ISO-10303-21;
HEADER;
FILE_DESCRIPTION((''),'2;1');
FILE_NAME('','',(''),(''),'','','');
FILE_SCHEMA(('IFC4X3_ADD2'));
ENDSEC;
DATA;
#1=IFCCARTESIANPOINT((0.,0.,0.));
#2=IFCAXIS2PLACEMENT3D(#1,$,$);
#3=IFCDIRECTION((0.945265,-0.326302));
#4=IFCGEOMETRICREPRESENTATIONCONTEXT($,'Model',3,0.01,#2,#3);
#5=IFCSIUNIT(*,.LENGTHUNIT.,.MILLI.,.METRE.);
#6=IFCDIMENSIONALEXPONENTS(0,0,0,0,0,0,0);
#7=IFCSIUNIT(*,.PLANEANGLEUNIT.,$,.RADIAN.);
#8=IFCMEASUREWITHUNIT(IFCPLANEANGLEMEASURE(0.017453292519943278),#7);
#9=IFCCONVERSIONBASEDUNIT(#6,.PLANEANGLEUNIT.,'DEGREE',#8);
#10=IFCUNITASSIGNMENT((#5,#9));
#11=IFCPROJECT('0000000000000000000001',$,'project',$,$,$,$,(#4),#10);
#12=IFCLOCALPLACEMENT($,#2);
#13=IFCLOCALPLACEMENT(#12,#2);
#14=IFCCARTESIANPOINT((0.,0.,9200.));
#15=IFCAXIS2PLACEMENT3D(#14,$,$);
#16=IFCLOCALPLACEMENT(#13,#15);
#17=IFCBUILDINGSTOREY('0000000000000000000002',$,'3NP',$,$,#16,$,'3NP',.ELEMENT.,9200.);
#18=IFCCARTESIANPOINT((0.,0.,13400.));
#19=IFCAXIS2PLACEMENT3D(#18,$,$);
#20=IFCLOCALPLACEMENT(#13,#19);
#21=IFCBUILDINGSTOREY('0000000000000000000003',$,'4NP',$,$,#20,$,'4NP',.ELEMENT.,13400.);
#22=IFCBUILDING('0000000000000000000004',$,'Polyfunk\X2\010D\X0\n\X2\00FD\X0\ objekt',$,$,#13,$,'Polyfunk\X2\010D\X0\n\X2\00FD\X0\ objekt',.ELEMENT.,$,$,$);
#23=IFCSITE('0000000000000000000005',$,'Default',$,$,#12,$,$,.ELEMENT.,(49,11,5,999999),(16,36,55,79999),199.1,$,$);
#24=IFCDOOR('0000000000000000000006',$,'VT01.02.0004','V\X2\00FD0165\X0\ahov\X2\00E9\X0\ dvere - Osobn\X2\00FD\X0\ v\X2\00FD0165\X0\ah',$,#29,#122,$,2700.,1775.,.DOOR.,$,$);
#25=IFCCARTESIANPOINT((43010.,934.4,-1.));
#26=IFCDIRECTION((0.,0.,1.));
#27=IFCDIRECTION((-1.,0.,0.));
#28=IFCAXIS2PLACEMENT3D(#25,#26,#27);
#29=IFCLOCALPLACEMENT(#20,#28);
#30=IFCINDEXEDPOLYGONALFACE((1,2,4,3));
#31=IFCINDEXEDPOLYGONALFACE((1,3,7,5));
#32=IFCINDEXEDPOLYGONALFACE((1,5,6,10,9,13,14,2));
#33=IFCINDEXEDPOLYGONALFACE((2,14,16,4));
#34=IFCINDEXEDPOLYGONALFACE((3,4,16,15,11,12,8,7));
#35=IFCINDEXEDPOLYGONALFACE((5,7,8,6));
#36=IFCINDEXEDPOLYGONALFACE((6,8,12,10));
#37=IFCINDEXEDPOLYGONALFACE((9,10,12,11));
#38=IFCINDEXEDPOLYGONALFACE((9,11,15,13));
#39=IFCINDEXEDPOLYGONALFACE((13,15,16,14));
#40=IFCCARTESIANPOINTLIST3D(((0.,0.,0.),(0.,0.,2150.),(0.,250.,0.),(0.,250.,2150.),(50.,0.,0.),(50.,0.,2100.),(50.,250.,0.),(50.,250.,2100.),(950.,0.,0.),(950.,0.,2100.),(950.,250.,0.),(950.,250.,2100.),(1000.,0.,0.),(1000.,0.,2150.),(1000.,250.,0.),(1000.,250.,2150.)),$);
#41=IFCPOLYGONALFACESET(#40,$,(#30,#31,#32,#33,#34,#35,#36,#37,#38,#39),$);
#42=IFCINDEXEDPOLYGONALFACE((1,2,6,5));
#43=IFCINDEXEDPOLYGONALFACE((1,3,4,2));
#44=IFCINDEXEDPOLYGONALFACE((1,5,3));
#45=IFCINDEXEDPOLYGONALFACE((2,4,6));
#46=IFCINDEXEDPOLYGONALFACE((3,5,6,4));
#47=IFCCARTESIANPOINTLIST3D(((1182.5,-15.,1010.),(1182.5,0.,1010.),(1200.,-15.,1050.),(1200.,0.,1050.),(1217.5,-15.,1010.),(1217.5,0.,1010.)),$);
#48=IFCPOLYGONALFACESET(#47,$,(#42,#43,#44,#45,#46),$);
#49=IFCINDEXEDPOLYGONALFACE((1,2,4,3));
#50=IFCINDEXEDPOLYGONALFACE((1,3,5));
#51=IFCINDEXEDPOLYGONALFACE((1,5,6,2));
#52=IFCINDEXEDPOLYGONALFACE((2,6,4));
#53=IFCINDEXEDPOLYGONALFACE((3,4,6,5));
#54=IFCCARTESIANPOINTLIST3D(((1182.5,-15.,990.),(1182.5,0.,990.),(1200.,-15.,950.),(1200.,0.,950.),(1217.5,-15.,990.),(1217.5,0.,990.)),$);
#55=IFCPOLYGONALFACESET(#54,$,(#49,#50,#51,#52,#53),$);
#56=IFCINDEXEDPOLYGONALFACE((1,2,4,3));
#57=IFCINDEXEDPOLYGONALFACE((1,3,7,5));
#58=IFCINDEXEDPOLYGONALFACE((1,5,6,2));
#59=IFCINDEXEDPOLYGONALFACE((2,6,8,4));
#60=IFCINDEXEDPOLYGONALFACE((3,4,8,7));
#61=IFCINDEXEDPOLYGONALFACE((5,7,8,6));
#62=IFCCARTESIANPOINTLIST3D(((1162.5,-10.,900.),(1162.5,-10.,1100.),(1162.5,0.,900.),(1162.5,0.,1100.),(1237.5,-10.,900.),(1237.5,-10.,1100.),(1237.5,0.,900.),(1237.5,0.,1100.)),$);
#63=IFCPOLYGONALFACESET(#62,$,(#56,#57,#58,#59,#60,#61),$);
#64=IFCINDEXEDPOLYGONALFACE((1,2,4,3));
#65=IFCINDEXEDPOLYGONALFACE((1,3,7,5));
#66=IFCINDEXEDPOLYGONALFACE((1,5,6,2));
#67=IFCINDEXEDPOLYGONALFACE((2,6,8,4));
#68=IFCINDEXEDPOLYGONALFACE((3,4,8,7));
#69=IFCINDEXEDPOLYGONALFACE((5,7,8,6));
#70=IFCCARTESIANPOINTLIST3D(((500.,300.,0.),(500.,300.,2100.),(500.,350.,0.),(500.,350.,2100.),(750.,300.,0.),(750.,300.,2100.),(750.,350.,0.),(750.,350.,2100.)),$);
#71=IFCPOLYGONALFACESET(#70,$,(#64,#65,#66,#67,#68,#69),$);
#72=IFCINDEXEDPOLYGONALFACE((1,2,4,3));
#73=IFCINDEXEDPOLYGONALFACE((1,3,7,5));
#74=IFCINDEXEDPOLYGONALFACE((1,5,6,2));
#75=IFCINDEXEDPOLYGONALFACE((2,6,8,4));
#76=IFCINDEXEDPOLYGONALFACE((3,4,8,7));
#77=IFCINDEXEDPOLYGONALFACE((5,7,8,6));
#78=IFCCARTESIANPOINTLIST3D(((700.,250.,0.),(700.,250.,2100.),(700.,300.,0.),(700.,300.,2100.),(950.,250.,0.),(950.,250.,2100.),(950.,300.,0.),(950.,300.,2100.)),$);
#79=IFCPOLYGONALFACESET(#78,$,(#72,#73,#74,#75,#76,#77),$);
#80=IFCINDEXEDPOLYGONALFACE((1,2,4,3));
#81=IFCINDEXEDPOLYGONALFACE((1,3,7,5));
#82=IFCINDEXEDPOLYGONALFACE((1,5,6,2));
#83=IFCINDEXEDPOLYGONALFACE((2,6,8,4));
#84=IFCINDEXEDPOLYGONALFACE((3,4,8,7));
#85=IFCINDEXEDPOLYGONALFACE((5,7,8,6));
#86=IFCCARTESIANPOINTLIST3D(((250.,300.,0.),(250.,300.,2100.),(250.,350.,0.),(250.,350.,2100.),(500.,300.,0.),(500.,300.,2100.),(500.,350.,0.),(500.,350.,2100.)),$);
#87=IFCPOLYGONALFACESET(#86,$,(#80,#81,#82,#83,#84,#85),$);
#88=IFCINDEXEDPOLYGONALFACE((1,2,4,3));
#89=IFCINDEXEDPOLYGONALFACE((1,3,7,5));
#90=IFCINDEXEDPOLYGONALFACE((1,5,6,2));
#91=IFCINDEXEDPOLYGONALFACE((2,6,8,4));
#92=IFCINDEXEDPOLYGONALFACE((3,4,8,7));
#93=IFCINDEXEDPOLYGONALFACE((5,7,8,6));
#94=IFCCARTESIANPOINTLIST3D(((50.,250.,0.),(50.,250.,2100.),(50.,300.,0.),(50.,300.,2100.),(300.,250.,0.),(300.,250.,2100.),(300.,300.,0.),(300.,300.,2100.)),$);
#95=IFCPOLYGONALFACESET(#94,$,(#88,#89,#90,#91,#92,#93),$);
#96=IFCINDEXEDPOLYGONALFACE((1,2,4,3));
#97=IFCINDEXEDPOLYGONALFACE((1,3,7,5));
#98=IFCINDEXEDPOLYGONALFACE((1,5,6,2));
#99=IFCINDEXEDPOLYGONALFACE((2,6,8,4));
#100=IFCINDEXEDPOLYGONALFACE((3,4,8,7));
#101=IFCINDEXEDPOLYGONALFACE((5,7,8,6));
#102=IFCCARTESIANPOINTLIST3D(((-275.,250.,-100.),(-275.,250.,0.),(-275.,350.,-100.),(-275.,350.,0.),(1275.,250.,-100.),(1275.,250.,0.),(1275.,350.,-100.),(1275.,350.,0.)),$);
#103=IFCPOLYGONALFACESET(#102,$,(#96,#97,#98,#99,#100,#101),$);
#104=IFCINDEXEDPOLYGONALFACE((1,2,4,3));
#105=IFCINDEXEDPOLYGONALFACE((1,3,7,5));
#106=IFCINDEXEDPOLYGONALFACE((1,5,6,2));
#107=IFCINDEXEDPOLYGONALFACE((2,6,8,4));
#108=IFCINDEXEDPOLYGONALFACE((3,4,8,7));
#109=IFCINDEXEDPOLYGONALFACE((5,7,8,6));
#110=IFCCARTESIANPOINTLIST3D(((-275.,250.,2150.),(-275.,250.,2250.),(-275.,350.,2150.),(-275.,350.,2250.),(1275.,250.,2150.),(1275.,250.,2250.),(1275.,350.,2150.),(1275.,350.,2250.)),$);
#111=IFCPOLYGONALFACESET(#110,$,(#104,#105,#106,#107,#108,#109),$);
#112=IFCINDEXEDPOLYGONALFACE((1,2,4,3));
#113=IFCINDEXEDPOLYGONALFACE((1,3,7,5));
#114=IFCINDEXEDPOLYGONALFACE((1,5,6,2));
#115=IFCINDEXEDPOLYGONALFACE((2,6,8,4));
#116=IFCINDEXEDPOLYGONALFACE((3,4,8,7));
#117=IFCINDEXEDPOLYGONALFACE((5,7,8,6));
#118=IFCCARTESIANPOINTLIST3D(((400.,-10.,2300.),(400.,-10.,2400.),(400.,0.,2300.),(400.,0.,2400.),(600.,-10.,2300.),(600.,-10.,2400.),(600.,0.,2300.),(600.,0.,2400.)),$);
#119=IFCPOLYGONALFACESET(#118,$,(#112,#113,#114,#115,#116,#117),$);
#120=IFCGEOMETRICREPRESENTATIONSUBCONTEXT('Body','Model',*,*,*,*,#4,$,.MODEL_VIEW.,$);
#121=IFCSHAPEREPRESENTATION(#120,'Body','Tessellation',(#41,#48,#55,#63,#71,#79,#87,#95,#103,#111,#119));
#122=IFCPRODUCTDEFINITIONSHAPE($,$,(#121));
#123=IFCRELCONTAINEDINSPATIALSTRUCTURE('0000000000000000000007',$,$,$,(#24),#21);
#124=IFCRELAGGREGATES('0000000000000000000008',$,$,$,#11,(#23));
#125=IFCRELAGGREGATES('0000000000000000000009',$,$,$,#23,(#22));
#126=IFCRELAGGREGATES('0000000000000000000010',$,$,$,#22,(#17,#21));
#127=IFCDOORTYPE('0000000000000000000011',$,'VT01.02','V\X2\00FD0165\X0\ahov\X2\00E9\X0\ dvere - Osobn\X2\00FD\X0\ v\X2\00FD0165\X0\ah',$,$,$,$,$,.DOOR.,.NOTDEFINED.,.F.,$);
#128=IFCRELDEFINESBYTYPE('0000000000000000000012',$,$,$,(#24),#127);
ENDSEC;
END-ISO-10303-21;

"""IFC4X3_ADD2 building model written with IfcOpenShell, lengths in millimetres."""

from ifc_helpers import new_model, entity, si_unit, converted_unit, direction, frame, frame_2d, origin, origin_2d_with_axis, place, context, subcontext, project, spatial, polyline, rectangle, outline, extrude, source, transform, mapped, type_object, type_shapes, element, save


model = new_model("IFC4X3_ADD2")

# Units and contexts
model_context = context("Model", 3, precision=0.01, world=origin(), true_north=direction((0.945265, -0.326302)))
body_context = subcontext(model_context, "Body", "Model", "MODEL_VIEW")
ifc_project = project(units=[si_unit("LENGTHUNIT", "METRE", prefix="MILLI"), converted_unit("PLANEANGLEUNIT", "DEGREE", entity("IfcPlaneAngleMeasure", 0.017453292519943278), si_unit("PLANEANGLEUNIT", "RADIAN"), dimensions=[0, 0, 0, 0, 0, 0, 0])], contexts=[model_context])

# Site, building, storey
site_placement = place(None, origin())
site = spatial("IfcSite", under=ifc_project, at=site_placement, Name="Default", CompositionType="ELEMENT", RefLatitude=(49, 11, 5, 999999), RefLongitude=(16, 36, 55, 79999), RefElevation=199.1)
building_placement = place(site_placement, origin())
building = spatial("IfcBuilding", under=site, at=building_placement, Name="Polyfunkčný objekt", LongName="Polyfunkčný objekt", CompositionType="ELEMENT")
storey_1_placement = place(building_placement, frame((0.0, 0.0, 9200.0)))
storey_1 = spatial("IfcBuildingStorey", under=building, at=storey_1_placement, Name="3NP", LongName="3NP", CompositionType="ELEMENT", Elevation=9200.0)

# Shared definitions
storey_2_placement = place(building_placement, frame((0.0, 0.0, 13400.0)))
storey_2 = spatial("IfcBuildingStorey", under=building, at=storey_2_placement, Name="4NP", LongName="4NP", CompositionType="ELEMENT", Elevation=13400.0)

# Door
door_type_1 = type_object("IfcDoorType", Name="VT01.02", Description="Výťahové dvere - Osobný výťah", OperationType="NOTDEFINED", ParameterTakesPrecedence=False, PredefinedType="DOOR")
shared_shape_1 = source(origin(), body_context, "Body", "SweptSolid", [
    extrude(outline(polyline([(-1087.5, -500.0), (1062.5, -500.0), (1062.5, -450.0), (-1037.5, -450.0), (-1037.5, 450.0), (1062.5, 450.0), (1062.5, 500.0), (-1087.5, 500.0), (-1087.5, -500.0)])), frame((500.0, 0.0, 1062.5), z_axis=(0.0, 1.0, 0.0), x_axis=(0.0, 0.0, -1.0)), (0.0, 0.0, 1.0), 250.0),
    extrude(outline(polyline([(-24.4, -10.7), (19.2, -10.7), (5.2, 21.4), (-24.4, -10.7)])), frame((1200.0, -15.0, 1023.3), z_axis=(0.0, 1.0, 0.0), x_axis=(0.400819, 0.0, -0.916157)), (0.0, 0.0, 1.0), 15.0),
    extrude(outline(polyline([(-24.4, -10.7), (19.2, -10.7), (5.2, 21.4), (-24.4, -10.7)])), frame((1200.0, -15.0, 976.7), z_axis=(0.0, 1.0, 0.0), x_axis=(-0.400819, 0.0, 0.916157)), (0.0, 0.0, 1.0), 15.0),
    extrude(rectangle(XDim=10.0, YDim=75.0, at=frame_2d((0.0, 0.0), x_axis=(1.0, 0.0))), frame((1200.0, -5.0, 900.0), z_axis=(0.0, 0.0, 1.0), x_axis=(0.0, 1.0, 0.0)), (0.0, 0.0, 1.0), 200.0),
    extrude(rectangle(XDim=50.0, YDim=250.0, at=origin_2d_with_axis()), frame((625.0, 325.0, 0.0), z_axis=(0.0, 0.0, 1.0), x_axis=(0.0, -1.0, 0.0)), (0.0, 0.0, 1.0), 2100.0),
    extrude(rectangle(XDim=50.0, YDim=250.0, at=frame_2d((0.0, 0.0), x_axis=(1.0, 0.0))), frame((825.0, 275.0, 0.0), z_axis=(0.0, 0.0, 1.0), x_axis=(0.0, -1.0, 0.0)), (0.0, 0.0, 1.0), 2100.0),
    extrude(rectangle(XDim=250.0, YDim=50.0, at=frame_2d((0.0, 0.0), x_axis=(1.0, 0.0))), frame((375.0, 325.0, 0.0), z_axis=(0.0, 0.0, 1.0), x_axis=(-1.0, 0.0, 0.0)), (0.0, 0.0, 1.0), 2100.0),
    extrude(rectangle(XDim=250.0, YDim=50.0, at=frame_2d((0.0, 0.0), x_axis=(1.0, 0.0))), frame((175.0, 275.0, 0.0), z_axis=(0.0, 0.0, 1.0), x_axis=(-1.0, 0.0, 0.0)), (0.0, 0.0, 1.0), 2100.0),
    extrude(rectangle(XDim=1550.0, YDim=100.0, at=frame_2d((0.0, 0.0), x_axis=(1.0, 0.0))), frame((500.0, 300.0, -100.0), z_axis=(0.0, 0.0, 1.0), x_axis=(-1.0, 0.0, 0.0)), (0.0, 0.0, 1.0), 100.0),
    extrude(rectangle(XDim=1550.0, YDim=100.0, at=frame_2d((0.0, 0.0), x_axis=(1.0, 0.0))), frame((500.0, 300.0, 2150.0), z_axis=(0.0, 0.0, 1.0), x_axis=(-1.0, 0.0, 0.0)), (0.0, 0.0, 1.0), 100.0),
    extrude(rectangle(XDim=10.0, YDim=200.0, at=frame_2d((0.0, 0.0), x_axis=(1.0, 0.0))), frame((500.0, -5.0, 2300.0), z_axis=(0.0, 0.0, 1.0), x_axis=(0.0, 1.0, 0.0)), (0.0, 0.0, 1.0), 100.0),
])
type_shapes(door_type_1, [shared_shape_1])
door_1_placement = place(storey_2_placement, frame((43010.0, 934.4, -1.0), z_axis=(0.0, 0.0, 1.0), x_axis=(-1.0, 0.0, 0.0)))
element("IfcDoor", 1, at=door_1_placement, inside=storey_2, type_object=door_type_1, Name="VT01.02.0004", Description="Výťahové dvere - Osobný výťah", OverallHeight=2700.0, OverallWidth=1775.0, PredefinedType="DOOR", context=body_context, shape_type="MappedRepresentation", body=[
    mapped(shared_shape_1, transform((0.0, 0.0, 0.0), scale=1.0)),
])

save(model, "model.ifc")
